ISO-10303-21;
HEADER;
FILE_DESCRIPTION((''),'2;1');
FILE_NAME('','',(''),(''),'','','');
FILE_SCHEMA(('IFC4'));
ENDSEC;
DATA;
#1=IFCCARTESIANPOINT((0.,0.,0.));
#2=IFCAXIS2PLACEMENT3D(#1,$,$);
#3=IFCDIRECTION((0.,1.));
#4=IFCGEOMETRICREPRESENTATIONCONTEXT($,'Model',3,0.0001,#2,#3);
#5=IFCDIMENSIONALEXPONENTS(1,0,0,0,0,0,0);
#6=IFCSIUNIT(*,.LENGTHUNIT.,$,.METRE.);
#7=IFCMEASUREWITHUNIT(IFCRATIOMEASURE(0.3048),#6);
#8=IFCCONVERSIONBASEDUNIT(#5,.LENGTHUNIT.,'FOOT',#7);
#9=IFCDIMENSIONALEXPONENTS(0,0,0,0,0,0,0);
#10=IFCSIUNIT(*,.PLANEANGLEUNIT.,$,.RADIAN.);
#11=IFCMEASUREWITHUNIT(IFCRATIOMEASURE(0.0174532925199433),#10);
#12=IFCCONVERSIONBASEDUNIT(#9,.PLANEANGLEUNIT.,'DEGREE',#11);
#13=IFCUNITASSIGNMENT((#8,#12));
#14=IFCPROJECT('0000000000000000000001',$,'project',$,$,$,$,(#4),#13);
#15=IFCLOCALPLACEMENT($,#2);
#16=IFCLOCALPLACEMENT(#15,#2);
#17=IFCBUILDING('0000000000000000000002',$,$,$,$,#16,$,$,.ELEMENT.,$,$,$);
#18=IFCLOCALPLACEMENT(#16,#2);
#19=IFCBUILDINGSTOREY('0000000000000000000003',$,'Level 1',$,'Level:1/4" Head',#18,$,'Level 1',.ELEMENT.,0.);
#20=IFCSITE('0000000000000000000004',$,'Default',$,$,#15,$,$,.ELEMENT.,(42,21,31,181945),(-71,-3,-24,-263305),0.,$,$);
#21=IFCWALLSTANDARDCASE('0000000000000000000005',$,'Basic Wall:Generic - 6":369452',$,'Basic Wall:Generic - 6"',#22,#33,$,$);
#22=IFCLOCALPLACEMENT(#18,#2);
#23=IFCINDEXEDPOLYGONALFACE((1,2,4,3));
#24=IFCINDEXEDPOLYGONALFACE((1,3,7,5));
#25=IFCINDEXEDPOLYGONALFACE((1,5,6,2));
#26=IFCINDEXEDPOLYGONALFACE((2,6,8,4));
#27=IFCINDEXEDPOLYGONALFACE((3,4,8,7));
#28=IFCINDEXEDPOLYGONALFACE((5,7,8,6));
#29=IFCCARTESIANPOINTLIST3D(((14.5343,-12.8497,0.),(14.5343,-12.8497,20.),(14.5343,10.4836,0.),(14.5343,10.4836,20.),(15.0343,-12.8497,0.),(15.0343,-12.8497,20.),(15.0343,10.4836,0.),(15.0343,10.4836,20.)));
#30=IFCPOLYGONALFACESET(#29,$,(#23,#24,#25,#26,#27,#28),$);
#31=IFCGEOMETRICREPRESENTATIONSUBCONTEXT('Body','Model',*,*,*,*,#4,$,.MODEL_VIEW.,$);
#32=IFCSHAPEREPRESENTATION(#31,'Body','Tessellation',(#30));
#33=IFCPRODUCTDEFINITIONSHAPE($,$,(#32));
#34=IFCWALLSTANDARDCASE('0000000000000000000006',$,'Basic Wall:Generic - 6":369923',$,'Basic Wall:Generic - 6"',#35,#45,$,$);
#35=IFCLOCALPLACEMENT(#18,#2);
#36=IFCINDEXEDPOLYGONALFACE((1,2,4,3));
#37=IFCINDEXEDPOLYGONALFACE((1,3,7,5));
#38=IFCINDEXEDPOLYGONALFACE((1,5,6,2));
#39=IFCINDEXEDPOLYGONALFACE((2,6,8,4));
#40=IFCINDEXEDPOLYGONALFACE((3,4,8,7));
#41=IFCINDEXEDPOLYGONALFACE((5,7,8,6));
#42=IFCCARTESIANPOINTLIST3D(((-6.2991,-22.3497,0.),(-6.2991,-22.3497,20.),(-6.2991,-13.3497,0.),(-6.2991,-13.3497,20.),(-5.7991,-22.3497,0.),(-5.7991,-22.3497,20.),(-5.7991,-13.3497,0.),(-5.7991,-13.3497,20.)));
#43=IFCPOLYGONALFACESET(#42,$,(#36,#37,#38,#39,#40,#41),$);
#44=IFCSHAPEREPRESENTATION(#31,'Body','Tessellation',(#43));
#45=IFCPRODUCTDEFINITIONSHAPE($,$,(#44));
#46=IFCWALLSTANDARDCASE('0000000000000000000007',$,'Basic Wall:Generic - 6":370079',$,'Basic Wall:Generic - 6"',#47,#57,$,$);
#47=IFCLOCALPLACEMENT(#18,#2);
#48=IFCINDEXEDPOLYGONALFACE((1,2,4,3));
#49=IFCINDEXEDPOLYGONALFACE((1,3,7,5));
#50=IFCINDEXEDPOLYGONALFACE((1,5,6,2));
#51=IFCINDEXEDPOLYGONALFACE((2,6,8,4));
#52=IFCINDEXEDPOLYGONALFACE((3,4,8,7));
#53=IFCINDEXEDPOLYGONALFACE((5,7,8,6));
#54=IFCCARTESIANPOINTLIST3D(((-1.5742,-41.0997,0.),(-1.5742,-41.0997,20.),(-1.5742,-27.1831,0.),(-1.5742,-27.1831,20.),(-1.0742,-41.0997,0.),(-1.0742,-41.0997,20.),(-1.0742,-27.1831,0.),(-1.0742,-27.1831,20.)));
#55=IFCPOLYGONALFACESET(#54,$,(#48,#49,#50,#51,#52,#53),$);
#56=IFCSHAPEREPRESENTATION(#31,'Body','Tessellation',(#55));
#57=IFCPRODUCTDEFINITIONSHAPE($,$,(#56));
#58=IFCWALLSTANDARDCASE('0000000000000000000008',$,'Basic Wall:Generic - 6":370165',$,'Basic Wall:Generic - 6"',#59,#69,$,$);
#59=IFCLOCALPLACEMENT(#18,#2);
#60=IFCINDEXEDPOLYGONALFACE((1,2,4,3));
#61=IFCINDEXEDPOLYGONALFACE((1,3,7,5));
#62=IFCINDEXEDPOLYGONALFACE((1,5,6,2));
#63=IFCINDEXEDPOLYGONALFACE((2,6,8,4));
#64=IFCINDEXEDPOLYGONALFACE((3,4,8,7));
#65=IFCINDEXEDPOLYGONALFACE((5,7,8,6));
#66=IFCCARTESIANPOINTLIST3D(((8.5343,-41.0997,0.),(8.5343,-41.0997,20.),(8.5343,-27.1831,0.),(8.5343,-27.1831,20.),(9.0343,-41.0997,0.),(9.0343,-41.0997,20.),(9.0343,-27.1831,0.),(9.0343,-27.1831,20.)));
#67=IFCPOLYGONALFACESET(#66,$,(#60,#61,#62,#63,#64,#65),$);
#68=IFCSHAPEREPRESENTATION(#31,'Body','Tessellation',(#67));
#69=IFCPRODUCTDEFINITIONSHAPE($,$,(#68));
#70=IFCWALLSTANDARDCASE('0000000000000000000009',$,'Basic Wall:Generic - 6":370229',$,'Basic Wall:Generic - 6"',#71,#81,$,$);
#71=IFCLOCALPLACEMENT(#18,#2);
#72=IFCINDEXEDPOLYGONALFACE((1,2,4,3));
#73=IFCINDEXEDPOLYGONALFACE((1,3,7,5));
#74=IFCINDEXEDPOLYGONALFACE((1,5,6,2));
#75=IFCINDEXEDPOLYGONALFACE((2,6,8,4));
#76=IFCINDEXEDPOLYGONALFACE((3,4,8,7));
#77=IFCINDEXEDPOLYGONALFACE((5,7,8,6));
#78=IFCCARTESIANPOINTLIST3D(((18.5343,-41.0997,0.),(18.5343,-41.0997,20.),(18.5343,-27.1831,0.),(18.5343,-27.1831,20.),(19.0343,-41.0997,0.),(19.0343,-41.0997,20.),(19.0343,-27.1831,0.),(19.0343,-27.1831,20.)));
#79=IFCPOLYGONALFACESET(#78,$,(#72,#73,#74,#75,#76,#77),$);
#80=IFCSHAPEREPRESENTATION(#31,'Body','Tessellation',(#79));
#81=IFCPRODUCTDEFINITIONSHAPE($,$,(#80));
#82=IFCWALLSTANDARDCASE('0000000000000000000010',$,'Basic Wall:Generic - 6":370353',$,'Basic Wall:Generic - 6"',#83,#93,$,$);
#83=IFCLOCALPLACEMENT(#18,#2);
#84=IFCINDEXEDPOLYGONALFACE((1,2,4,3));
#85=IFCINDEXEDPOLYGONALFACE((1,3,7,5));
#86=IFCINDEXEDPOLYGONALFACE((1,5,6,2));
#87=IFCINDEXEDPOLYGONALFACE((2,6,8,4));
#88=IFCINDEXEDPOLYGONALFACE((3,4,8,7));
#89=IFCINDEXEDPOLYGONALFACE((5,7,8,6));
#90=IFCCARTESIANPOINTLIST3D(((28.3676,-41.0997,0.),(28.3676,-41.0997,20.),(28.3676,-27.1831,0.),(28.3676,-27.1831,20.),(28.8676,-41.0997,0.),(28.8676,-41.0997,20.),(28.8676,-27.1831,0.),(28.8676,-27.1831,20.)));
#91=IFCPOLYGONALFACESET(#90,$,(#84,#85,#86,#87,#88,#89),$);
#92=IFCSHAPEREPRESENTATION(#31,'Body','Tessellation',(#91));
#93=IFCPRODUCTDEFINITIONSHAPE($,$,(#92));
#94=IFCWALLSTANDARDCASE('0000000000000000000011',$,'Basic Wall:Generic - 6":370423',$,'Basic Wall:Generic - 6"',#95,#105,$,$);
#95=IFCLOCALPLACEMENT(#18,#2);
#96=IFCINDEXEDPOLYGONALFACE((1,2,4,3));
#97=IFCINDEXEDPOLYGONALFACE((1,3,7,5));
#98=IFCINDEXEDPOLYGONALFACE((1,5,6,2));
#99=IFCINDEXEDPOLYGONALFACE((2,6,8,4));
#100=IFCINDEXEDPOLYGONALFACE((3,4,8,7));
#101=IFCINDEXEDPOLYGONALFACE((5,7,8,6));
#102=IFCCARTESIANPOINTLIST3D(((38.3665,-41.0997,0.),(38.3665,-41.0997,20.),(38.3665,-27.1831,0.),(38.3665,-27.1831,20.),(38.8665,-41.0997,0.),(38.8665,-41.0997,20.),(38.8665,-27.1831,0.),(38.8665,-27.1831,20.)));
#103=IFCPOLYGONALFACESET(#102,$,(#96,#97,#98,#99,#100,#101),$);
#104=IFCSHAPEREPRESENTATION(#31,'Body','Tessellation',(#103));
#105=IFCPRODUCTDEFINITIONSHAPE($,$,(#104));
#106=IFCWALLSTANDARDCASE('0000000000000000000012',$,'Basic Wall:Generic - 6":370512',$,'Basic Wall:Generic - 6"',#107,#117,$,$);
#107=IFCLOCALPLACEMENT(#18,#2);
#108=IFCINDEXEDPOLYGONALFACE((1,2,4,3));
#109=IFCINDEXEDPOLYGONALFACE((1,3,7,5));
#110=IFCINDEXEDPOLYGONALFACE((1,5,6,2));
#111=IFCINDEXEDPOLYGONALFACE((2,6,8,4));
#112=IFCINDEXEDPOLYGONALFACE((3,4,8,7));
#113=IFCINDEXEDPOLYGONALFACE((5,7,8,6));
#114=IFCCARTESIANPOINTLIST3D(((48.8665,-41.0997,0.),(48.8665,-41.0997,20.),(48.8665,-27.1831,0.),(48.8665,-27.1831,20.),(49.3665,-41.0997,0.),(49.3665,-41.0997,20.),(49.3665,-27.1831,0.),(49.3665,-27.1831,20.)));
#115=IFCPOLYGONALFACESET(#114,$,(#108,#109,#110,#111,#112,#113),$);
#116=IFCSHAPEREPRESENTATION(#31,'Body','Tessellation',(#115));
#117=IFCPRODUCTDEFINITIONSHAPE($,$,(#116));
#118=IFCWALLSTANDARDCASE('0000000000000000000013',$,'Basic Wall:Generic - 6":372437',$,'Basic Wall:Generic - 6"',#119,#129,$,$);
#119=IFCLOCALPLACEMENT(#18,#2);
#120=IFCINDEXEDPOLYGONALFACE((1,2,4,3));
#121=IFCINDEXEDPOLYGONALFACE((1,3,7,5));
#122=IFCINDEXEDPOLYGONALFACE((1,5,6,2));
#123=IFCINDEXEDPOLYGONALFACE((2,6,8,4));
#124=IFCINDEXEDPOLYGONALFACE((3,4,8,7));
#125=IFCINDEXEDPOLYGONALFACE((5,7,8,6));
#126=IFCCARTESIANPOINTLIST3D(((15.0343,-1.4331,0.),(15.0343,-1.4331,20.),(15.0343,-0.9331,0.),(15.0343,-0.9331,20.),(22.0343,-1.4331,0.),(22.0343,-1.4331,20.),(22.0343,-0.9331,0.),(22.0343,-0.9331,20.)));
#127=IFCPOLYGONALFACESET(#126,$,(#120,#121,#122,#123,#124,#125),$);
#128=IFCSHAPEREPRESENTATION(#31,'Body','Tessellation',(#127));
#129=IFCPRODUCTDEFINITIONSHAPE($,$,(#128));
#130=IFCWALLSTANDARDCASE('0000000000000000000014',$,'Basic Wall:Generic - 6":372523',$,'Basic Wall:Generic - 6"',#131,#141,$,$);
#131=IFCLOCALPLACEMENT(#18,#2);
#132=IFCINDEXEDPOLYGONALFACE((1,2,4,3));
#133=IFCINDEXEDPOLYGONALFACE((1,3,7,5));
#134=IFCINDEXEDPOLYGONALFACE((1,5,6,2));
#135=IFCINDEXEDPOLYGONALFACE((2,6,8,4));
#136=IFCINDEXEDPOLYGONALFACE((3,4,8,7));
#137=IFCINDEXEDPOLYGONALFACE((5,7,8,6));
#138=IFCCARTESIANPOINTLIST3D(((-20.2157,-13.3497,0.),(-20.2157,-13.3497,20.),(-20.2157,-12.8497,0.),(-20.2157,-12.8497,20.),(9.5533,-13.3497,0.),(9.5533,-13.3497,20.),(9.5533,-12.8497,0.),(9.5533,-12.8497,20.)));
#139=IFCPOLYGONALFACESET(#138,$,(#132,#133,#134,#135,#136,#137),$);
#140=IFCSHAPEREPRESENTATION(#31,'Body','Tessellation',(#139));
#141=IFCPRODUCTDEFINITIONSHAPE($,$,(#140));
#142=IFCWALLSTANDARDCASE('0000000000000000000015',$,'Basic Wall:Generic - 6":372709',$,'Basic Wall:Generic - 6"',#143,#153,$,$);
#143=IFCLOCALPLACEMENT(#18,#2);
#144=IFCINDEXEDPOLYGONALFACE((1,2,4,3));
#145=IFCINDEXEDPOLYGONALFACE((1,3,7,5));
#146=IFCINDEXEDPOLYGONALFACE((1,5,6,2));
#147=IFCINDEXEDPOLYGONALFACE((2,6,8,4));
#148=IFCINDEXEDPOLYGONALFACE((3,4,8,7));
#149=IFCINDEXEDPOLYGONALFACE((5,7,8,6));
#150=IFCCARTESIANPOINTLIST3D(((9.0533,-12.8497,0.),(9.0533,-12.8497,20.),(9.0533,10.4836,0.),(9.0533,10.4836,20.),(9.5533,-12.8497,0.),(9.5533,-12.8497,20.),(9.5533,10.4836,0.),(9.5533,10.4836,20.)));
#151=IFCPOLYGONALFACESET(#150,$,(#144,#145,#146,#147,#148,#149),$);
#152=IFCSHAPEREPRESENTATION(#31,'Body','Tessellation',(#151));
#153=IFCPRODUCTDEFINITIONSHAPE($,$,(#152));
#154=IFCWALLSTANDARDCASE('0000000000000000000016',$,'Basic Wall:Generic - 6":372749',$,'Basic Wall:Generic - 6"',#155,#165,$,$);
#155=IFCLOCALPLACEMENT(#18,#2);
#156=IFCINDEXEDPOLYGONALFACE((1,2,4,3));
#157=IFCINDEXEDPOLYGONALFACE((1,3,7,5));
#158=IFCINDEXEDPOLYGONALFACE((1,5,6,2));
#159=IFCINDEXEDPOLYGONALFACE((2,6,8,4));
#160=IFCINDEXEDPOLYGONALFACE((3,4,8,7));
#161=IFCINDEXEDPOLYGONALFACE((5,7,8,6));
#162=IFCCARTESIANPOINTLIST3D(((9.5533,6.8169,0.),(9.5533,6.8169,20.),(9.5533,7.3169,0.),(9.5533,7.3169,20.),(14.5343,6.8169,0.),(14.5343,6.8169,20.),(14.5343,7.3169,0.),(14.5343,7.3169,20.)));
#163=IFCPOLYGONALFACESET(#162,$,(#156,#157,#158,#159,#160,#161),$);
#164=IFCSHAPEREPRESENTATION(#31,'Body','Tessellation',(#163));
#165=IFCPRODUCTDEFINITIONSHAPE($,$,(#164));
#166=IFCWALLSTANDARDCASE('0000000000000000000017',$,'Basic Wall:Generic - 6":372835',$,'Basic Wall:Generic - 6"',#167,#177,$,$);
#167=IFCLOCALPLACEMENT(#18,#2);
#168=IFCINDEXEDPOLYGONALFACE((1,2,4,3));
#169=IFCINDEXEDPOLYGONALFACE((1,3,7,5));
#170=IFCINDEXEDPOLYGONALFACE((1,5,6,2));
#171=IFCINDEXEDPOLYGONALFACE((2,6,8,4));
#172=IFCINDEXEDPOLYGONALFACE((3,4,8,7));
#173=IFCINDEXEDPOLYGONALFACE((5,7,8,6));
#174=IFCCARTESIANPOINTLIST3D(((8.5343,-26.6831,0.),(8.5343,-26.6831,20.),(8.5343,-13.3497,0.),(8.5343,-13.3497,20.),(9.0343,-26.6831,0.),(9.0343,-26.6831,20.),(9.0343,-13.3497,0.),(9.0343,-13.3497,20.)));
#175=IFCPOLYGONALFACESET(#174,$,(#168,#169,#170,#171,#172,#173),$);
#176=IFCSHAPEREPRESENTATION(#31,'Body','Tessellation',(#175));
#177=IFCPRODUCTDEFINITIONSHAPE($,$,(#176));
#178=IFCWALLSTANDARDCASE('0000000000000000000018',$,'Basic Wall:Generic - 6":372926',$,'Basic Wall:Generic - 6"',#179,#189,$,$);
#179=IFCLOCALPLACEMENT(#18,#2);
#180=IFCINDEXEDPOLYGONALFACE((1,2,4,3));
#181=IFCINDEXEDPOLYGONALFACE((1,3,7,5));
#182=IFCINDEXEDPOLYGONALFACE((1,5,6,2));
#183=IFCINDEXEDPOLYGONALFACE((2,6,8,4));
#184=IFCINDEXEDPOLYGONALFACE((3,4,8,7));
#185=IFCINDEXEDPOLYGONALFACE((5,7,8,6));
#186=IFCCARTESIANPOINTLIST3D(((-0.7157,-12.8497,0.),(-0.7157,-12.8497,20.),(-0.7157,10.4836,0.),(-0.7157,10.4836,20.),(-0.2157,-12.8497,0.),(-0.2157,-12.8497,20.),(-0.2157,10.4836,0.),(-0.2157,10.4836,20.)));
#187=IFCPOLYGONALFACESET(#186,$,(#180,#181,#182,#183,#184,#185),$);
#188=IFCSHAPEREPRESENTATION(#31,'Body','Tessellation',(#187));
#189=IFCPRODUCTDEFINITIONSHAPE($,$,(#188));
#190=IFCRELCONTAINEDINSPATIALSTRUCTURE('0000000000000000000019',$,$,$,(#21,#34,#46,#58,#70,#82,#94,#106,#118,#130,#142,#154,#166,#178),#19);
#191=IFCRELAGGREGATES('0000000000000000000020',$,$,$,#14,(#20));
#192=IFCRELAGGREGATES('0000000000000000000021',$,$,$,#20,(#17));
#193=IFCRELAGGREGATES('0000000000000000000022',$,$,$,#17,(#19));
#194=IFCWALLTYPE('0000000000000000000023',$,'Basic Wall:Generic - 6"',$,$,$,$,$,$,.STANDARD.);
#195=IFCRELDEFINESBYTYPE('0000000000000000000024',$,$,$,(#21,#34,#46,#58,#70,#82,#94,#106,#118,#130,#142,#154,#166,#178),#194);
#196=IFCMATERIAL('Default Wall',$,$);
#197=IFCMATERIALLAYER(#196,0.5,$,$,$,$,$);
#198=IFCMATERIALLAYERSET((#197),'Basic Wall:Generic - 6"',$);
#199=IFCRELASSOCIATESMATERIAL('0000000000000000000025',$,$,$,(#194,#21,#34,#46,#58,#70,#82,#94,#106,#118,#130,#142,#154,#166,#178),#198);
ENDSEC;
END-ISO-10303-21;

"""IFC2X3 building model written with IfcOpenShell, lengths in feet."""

from ifc_helpers import new_model, entity, si_unit, converted_unit, direction, frame, frame_2d, origin, place, context, subcontext, project, spatial, rectangle, extrude, material, layer, layer_set, layer_usage, type_object, element, save


model = new_model("IFC2X3")

# Units and contexts
model_context = context("Model", 3, precision=0.0001, world=origin(), true_north=direction((0.0, 1.0)))
body_context = subcontext(model_context, "Body", "Model", "MODEL_VIEW")
ifc_project = project(units=[converted_unit("LENGTHUNIT", "FOOT", entity("IfcRatioMeasure", 0.3048), si_unit("LENGTHUNIT", "METRE"), dimensions=[1, 0, 0, 0, 0, 0, 0]), converted_unit("PLANEANGLEUNIT", "DEGREE", entity("IfcRatioMeasure", 0.0174532925199433), si_unit("PLANEANGLEUNIT", "RADIAN"), dimensions=[0, 0, 0, 0, 0, 0, 0])], contexts=[model_context])

# Site, building, storey
site_placement = place(None, origin())
site = spatial("IfcSite", under=ifc_project, at=site_placement, Name="Default", CompositionType="ELEMENT", RefLatitude=(42, 21, 31, 181945), RefLongitude=(-71, -3, -24, -263305), RefElevation=0.0)
building_placement = place(site_placement, origin())
building = spatial("IfcBuilding", under=site, at=building_placement, CompositionType="ELEMENT")
storey_placement = place(building_placement, origin())
storey = spatial("IfcBuildingStorey", under=building, at=storey_placement, Name="Level 1", ObjectType="Level:1/4\" Head", LongName="Level 1", CompositionType="ELEMENT", Elevation=0.0)

# Walls
ifc_material = material(Name="Default Wall")
ifc_layer = layer(ifc_material, 0.5)
ifc_layer_set = layer_set([ifc_layer], Name="Basic Wall:Generic - 6\"")
ifc_layer_usage_1 = layer_usage(ifc_layer_set, "AXIS2", "NEGATIVE", 0.25)
wall_type = type_object("IfcWallType", Name="Basic Wall:Generic - 6\"", PredefinedType="STANDARD", material=ifc_layer_set)
wall_1_placement = place(storey_placement, frame((14.7843, -12.8497, 0.0), z_axis=(0.0, 0.0, 1.0), x_axis=(0.0, 1.0, 0.0)))
element("IfcWallStandardCase", 1, at=wall_1_placement, inside=storey, type_object=wall_type, material=ifc_layer_usage_1, Name="Basic Wall:Generic - 6\":369452", ObjectType="Basic Wall:Generic - 6\"", context=body_context, shape_type="SweptSolid", body=[
    extrude(rectangle(XDim=23.3333, YDim=0.5, at=frame_2d((11.6667, 0.0), x_axis=(-1.0, 0.0))), origin(), (0.0, 0.0, 1.0), 20.0),
])
ifc_layer_usage_2 = layer_usage(ifc_layer_set, "AXIS2", "NEGATIVE", 0.25)
wall_2_placement = place(storey_placement, frame((-6.0491, -13.3497, 0.0), z_axis=(0.0, 0.0, 1.0), x_axis=(0.0, -1.0, 0.0)))
element("IfcWallStandardCase", 2, at=wall_2_placement, inside=storey, type_object=wall_type, material=ifc_layer_usage_2, Name="Basic Wall:Generic - 6\":369923", ObjectType="Basic Wall:Generic - 6\"", context=body_context, shape_type="SweptSolid", body=[
    extrude(rectangle(XDim=9.0, YDim=0.5, at=frame_2d((4.5, 0.0), x_axis=(-1.0, 0.0))), origin(), (0.0, 0.0, 1.0), 20.0),
])
ifc_layer_usage_3 = layer_usage(ifc_layer_set, "AXIS2", "NEGATIVE", 0.25)
wall_3_placement = place(storey_placement, frame((-1.3242, -27.1831, 0.0), z_axis=(0.0, 0.0, 1.0), x_axis=(0.0, -1.0, 0.0)))
element("IfcWallStandardCase", 3, at=wall_3_placement, inside=storey, type_object=wall_type, material=ifc_layer_usage_3, Name="Basic Wall:Generic - 6\":370079", ObjectType="Basic Wall:Generic - 6\"", context=body_context, shape_type="SweptSolid", body=[
    extrude(rectangle(XDim=13.9167, YDim=0.5, at=frame_2d((6.9583, 0.0), x_axis=(-1.0, 0.0))), origin(), (0.0, 0.0, 1.0), 20.0),
])
ifc_layer_usage_4 = layer_usage(ifc_layer_set, "AXIS2", "NEGATIVE", 0.25)
wall_4_placement = place(storey_placement, frame((8.7843, -27.1831, 0.0), z_axis=(0.0, 0.0, 1.0), x_axis=(0.0, -1.0, 0.0)))
element("IfcWallStandardCase", 4, at=wall_4_placement, inside=storey, type_object=wall_type, material=ifc_layer_usage_4, Name="Basic Wall:Generic - 6\":370165", ObjectType="Basic Wall:Generic - 6\"", context=body_context, shape_type="SweptSolid", body=[
    extrude(rectangle(XDim=13.9167, YDim=0.5, at=frame_2d((6.9583, 0.0), x_axis=(-1.0, 0.0))), origin(), (0.0, 0.0, 1.0), 20.0),
])
ifc_layer_usage_5 = layer_usage(ifc_layer_set, "AXIS2", "NEGATIVE", 0.25)
wall_5_placement = place(storey_placement, frame((18.7843, -27.1831, 0.0), z_axis=(0.0, 0.0, 1.0), x_axis=(0.0, -1.0, 0.0)))
element("IfcWallStandardCase", 5, at=wall_5_placement, inside=storey, type_object=wall_type, material=ifc_layer_usage_5, Name="Basic Wall:Generic - 6\":370229", ObjectType="Basic Wall:Generic - 6\"", context=body_context, shape_type="SweptSolid", body=[
    extrude(rectangle(XDim=13.9167, YDim=0.5, at=frame_2d((6.9583, 0.0), x_axis=(-1.0, 0.0))), origin(), (0.0, 0.0, 1.0), 20.0),
])
ifc_layer_usage_6 = layer_usage(ifc_layer_set, "AXIS2", "NEGATIVE", 0.25)
wall_6_placement = place(storey_placement, frame((28.6176, -27.1831, 0.0), z_axis=(0.0, 0.0, 1.0), x_axis=(0.0, -1.0, 0.0)))
element("IfcWallStandardCase", 6, at=wall_6_placement, inside=storey, type_object=wall_type, material=ifc_layer_usage_6, Name="Basic Wall:Generic - 6\":370353", ObjectType="Basic Wall:Generic - 6\"", context=body_context, shape_type="SweptSolid", body=[
    extrude(rectangle(XDim=13.9167, YDim=0.5, at=frame_2d((6.9583, 0.0), x_axis=(-1.0, 0.0))), origin(), (0.0, 0.0, 1.0), 20.0),
])
ifc_layer_usage_7 = layer_usage(ifc_layer_set, "AXIS2", "NEGATIVE", 0.25)
wall_7_placement = place(storey_placement, frame((38.6165, -27.1831, 0.0), z_axis=(0.0, 0.0, 1.0), x_axis=(0.0, -1.0, 0.0)))
element("IfcWallStandardCase", 7, at=wall_7_placement, inside=storey, type_object=wall_type, material=ifc_layer_usage_7, Name="Basic Wall:Generic - 6\":370423", ObjectType="Basic Wall:Generic - 6\"", context=body_context, shape_type="SweptSolid", body=[
    extrude(rectangle(XDim=13.9167, YDim=0.5, at=frame_2d((6.9583, 0.0), x_axis=(-1.0, 0.0))), origin(), (0.0, 0.0, 1.0), 20.0),
])
ifc_layer_usage_8 = layer_usage(ifc_layer_set, "AXIS2", "NEGATIVE", 0.25)
wall_8_placement = place(storey_placement, frame((49.1165, -27.1831, 0.0), z_axis=(0.0, 0.0, 1.0), x_axis=(0.0, -1.0, 0.0)))
element("IfcWallStandardCase", 8, at=wall_8_placement, inside=storey, type_object=wall_type, material=ifc_layer_usage_8, Name="Basic Wall:Generic - 6\":370512", ObjectType="Basic Wall:Generic - 6\"", context=body_context, shape_type="SweptSolid", body=[
    extrude(rectangle(XDim=13.9167, YDim=0.5, at=frame_2d((6.9583, 0.0), x_axis=(-1.0, 0.0))), origin(), (0.0, 0.0, 1.0), 20.0),
])
ifc_layer_usage_9 = layer_usage(ifc_layer_set, "AXIS2", "NEGATIVE", 0.25)
wall_9_placement = place(storey_placement, frame((15.0343, -1.1831, 0.0)))
element("IfcWallStandardCase", 9, at=wall_9_placement, inside=storey, type_object=wall_type, material=ifc_layer_usage_9, Name="Basic Wall:Generic - 6\":372437", ObjectType="Basic Wall:Generic - 6\"", context=body_context, shape_type="SweptSolid", body=[
    extrude(rectangle(XDim=7.0, YDim=0.5, at=frame_2d((3.5, 0.0), x_axis=(-1.0, 0.0))), origin(), (0.0, 0.0, 1.0), 20.0),
])
ifc_layer_usage_10 = layer_usage(ifc_layer_set, "AXIS2", "NEGATIVE", 0.25)
wall_10_placement = place(storey_placement, frame((9.5533, -13.0997, 0.0), z_axis=(0.0, 0.0, 1.0), x_axis=(-1.0, 0.0, 0.0)))
element("IfcWallStandardCase", 10, at=wall_10_placement, inside=storey, type_object=wall_type, material=ifc_layer_usage_10, Name="Basic Wall:Generic - 6\":372523", ObjectType="Basic Wall:Generic - 6\"", context=body_context, shape_type="SweptSolid", body=[
    extrude(rectangle(XDim=29.769, YDim=0.5, at=frame_2d((14.8845, 0.0), x_axis=(-1.0, 0.0))), origin(), (0.0, 0.0, 1.0), 20.0),
])
ifc_layer_usage_11 = layer_usage(ifc_layer_set, "AXIS2", "NEGATIVE", 0.25)
wall_11_placement = place(storey_placement, frame((9.3033, -12.8497, 0.0), z_axis=(0.0, 0.0, 1.0), x_axis=(0.0, 1.0, 0.0)))
element("IfcWallStandardCase", 11, at=wall_11_placement, inside=storey, type_object=wall_type, material=ifc_layer_usage_11, Name="Basic Wall:Generic - 6\":372709", ObjectType="Basic Wall:Generic - 6\"", context=body_context, shape_type="SweptSolid", body=[
    extrude(rectangle(XDim=23.3333, YDim=0.5, at=frame_2d((11.6667, 0.0), x_axis=(-1.0, 0.0))), origin(), (0.0, 0.0, 1.0), 20.0),
])
ifc_layer_usage_12 = layer_usage(ifc_layer_set, "AXIS2", "NEGATIVE", 0.25)
wall_12_placement = place(storey_placement, frame((9.5533, 7.0669, 0.0)))
element("IfcWallStandardCase", 12, at=wall_12_placement, inside=storey, type_object=wall_type, material=ifc_layer_usage_12, Name="Basic Wall:Generic - 6\":372749", ObjectType="Basic Wall:Generic - 6\"", context=body_context, shape_type="SweptSolid", body=[
    extrude(rectangle(XDim=4.981, YDim=0.5, at=frame_2d((2.4905, 0.0), x_axis=(-1.0, 0.0))), origin(), (0.0, 0.0, 1.0), 20.0),
])
ifc_layer_usage_13 = layer_usage(ifc_layer_set, "AXIS2", "NEGATIVE", 0.25)
wall_13_placement = place(storey_placement, frame((8.7843, -13.3497, 0.0), z_axis=(0.0, 0.0, 1.0), x_axis=(0.0, -1.0, 0.0)))
element("IfcWallStandardCase", 13, at=wall_13_placement, inside=storey, type_object=wall_type, material=ifc_layer_usage_13, Name="Basic Wall:Generic - 6\":372835", ObjectType="Basic Wall:Generic - 6\"", context=body_context, shape_type="SweptSolid", body=[
    extrude(rectangle(XDim=13.3333, YDim=0.5, at=frame_2d((6.6667, 0.0), x_axis=(-1.0, 0.0))), origin(), (0.0, 0.0, 1.0), 20.0),
])
ifc_layer_usage_14 = layer_usage(ifc_layer_set, "AXIS2", "NEGATIVE", 0.25)
wall_14_placement = place(storey_placement, frame((-0.4657, -12.8497, 0.0), z_axis=(0.0, 0.0, 1.0), x_axis=(0.0, 1.0, 0.0)))
element("IfcWallStandardCase", 14, at=wall_14_placement, inside=storey, type_object=wall_type, material=ifc_layer_usage_14, Name="Basic Wall:Generic - 6\":372926", ObjectType="Basic Wall:Generic - 6\"", context=body_context, shape_type="SweptSolid", body=[
    extrude(rectangle(XDim=23.3333, YDim=0.5, at=frame_2d((11.6667, 0.0), x_axis=(-1.0, 0.0))), origin(), (0.0, 0.0, 1.0), 20.0),
])

save(model, "model.ifc")
